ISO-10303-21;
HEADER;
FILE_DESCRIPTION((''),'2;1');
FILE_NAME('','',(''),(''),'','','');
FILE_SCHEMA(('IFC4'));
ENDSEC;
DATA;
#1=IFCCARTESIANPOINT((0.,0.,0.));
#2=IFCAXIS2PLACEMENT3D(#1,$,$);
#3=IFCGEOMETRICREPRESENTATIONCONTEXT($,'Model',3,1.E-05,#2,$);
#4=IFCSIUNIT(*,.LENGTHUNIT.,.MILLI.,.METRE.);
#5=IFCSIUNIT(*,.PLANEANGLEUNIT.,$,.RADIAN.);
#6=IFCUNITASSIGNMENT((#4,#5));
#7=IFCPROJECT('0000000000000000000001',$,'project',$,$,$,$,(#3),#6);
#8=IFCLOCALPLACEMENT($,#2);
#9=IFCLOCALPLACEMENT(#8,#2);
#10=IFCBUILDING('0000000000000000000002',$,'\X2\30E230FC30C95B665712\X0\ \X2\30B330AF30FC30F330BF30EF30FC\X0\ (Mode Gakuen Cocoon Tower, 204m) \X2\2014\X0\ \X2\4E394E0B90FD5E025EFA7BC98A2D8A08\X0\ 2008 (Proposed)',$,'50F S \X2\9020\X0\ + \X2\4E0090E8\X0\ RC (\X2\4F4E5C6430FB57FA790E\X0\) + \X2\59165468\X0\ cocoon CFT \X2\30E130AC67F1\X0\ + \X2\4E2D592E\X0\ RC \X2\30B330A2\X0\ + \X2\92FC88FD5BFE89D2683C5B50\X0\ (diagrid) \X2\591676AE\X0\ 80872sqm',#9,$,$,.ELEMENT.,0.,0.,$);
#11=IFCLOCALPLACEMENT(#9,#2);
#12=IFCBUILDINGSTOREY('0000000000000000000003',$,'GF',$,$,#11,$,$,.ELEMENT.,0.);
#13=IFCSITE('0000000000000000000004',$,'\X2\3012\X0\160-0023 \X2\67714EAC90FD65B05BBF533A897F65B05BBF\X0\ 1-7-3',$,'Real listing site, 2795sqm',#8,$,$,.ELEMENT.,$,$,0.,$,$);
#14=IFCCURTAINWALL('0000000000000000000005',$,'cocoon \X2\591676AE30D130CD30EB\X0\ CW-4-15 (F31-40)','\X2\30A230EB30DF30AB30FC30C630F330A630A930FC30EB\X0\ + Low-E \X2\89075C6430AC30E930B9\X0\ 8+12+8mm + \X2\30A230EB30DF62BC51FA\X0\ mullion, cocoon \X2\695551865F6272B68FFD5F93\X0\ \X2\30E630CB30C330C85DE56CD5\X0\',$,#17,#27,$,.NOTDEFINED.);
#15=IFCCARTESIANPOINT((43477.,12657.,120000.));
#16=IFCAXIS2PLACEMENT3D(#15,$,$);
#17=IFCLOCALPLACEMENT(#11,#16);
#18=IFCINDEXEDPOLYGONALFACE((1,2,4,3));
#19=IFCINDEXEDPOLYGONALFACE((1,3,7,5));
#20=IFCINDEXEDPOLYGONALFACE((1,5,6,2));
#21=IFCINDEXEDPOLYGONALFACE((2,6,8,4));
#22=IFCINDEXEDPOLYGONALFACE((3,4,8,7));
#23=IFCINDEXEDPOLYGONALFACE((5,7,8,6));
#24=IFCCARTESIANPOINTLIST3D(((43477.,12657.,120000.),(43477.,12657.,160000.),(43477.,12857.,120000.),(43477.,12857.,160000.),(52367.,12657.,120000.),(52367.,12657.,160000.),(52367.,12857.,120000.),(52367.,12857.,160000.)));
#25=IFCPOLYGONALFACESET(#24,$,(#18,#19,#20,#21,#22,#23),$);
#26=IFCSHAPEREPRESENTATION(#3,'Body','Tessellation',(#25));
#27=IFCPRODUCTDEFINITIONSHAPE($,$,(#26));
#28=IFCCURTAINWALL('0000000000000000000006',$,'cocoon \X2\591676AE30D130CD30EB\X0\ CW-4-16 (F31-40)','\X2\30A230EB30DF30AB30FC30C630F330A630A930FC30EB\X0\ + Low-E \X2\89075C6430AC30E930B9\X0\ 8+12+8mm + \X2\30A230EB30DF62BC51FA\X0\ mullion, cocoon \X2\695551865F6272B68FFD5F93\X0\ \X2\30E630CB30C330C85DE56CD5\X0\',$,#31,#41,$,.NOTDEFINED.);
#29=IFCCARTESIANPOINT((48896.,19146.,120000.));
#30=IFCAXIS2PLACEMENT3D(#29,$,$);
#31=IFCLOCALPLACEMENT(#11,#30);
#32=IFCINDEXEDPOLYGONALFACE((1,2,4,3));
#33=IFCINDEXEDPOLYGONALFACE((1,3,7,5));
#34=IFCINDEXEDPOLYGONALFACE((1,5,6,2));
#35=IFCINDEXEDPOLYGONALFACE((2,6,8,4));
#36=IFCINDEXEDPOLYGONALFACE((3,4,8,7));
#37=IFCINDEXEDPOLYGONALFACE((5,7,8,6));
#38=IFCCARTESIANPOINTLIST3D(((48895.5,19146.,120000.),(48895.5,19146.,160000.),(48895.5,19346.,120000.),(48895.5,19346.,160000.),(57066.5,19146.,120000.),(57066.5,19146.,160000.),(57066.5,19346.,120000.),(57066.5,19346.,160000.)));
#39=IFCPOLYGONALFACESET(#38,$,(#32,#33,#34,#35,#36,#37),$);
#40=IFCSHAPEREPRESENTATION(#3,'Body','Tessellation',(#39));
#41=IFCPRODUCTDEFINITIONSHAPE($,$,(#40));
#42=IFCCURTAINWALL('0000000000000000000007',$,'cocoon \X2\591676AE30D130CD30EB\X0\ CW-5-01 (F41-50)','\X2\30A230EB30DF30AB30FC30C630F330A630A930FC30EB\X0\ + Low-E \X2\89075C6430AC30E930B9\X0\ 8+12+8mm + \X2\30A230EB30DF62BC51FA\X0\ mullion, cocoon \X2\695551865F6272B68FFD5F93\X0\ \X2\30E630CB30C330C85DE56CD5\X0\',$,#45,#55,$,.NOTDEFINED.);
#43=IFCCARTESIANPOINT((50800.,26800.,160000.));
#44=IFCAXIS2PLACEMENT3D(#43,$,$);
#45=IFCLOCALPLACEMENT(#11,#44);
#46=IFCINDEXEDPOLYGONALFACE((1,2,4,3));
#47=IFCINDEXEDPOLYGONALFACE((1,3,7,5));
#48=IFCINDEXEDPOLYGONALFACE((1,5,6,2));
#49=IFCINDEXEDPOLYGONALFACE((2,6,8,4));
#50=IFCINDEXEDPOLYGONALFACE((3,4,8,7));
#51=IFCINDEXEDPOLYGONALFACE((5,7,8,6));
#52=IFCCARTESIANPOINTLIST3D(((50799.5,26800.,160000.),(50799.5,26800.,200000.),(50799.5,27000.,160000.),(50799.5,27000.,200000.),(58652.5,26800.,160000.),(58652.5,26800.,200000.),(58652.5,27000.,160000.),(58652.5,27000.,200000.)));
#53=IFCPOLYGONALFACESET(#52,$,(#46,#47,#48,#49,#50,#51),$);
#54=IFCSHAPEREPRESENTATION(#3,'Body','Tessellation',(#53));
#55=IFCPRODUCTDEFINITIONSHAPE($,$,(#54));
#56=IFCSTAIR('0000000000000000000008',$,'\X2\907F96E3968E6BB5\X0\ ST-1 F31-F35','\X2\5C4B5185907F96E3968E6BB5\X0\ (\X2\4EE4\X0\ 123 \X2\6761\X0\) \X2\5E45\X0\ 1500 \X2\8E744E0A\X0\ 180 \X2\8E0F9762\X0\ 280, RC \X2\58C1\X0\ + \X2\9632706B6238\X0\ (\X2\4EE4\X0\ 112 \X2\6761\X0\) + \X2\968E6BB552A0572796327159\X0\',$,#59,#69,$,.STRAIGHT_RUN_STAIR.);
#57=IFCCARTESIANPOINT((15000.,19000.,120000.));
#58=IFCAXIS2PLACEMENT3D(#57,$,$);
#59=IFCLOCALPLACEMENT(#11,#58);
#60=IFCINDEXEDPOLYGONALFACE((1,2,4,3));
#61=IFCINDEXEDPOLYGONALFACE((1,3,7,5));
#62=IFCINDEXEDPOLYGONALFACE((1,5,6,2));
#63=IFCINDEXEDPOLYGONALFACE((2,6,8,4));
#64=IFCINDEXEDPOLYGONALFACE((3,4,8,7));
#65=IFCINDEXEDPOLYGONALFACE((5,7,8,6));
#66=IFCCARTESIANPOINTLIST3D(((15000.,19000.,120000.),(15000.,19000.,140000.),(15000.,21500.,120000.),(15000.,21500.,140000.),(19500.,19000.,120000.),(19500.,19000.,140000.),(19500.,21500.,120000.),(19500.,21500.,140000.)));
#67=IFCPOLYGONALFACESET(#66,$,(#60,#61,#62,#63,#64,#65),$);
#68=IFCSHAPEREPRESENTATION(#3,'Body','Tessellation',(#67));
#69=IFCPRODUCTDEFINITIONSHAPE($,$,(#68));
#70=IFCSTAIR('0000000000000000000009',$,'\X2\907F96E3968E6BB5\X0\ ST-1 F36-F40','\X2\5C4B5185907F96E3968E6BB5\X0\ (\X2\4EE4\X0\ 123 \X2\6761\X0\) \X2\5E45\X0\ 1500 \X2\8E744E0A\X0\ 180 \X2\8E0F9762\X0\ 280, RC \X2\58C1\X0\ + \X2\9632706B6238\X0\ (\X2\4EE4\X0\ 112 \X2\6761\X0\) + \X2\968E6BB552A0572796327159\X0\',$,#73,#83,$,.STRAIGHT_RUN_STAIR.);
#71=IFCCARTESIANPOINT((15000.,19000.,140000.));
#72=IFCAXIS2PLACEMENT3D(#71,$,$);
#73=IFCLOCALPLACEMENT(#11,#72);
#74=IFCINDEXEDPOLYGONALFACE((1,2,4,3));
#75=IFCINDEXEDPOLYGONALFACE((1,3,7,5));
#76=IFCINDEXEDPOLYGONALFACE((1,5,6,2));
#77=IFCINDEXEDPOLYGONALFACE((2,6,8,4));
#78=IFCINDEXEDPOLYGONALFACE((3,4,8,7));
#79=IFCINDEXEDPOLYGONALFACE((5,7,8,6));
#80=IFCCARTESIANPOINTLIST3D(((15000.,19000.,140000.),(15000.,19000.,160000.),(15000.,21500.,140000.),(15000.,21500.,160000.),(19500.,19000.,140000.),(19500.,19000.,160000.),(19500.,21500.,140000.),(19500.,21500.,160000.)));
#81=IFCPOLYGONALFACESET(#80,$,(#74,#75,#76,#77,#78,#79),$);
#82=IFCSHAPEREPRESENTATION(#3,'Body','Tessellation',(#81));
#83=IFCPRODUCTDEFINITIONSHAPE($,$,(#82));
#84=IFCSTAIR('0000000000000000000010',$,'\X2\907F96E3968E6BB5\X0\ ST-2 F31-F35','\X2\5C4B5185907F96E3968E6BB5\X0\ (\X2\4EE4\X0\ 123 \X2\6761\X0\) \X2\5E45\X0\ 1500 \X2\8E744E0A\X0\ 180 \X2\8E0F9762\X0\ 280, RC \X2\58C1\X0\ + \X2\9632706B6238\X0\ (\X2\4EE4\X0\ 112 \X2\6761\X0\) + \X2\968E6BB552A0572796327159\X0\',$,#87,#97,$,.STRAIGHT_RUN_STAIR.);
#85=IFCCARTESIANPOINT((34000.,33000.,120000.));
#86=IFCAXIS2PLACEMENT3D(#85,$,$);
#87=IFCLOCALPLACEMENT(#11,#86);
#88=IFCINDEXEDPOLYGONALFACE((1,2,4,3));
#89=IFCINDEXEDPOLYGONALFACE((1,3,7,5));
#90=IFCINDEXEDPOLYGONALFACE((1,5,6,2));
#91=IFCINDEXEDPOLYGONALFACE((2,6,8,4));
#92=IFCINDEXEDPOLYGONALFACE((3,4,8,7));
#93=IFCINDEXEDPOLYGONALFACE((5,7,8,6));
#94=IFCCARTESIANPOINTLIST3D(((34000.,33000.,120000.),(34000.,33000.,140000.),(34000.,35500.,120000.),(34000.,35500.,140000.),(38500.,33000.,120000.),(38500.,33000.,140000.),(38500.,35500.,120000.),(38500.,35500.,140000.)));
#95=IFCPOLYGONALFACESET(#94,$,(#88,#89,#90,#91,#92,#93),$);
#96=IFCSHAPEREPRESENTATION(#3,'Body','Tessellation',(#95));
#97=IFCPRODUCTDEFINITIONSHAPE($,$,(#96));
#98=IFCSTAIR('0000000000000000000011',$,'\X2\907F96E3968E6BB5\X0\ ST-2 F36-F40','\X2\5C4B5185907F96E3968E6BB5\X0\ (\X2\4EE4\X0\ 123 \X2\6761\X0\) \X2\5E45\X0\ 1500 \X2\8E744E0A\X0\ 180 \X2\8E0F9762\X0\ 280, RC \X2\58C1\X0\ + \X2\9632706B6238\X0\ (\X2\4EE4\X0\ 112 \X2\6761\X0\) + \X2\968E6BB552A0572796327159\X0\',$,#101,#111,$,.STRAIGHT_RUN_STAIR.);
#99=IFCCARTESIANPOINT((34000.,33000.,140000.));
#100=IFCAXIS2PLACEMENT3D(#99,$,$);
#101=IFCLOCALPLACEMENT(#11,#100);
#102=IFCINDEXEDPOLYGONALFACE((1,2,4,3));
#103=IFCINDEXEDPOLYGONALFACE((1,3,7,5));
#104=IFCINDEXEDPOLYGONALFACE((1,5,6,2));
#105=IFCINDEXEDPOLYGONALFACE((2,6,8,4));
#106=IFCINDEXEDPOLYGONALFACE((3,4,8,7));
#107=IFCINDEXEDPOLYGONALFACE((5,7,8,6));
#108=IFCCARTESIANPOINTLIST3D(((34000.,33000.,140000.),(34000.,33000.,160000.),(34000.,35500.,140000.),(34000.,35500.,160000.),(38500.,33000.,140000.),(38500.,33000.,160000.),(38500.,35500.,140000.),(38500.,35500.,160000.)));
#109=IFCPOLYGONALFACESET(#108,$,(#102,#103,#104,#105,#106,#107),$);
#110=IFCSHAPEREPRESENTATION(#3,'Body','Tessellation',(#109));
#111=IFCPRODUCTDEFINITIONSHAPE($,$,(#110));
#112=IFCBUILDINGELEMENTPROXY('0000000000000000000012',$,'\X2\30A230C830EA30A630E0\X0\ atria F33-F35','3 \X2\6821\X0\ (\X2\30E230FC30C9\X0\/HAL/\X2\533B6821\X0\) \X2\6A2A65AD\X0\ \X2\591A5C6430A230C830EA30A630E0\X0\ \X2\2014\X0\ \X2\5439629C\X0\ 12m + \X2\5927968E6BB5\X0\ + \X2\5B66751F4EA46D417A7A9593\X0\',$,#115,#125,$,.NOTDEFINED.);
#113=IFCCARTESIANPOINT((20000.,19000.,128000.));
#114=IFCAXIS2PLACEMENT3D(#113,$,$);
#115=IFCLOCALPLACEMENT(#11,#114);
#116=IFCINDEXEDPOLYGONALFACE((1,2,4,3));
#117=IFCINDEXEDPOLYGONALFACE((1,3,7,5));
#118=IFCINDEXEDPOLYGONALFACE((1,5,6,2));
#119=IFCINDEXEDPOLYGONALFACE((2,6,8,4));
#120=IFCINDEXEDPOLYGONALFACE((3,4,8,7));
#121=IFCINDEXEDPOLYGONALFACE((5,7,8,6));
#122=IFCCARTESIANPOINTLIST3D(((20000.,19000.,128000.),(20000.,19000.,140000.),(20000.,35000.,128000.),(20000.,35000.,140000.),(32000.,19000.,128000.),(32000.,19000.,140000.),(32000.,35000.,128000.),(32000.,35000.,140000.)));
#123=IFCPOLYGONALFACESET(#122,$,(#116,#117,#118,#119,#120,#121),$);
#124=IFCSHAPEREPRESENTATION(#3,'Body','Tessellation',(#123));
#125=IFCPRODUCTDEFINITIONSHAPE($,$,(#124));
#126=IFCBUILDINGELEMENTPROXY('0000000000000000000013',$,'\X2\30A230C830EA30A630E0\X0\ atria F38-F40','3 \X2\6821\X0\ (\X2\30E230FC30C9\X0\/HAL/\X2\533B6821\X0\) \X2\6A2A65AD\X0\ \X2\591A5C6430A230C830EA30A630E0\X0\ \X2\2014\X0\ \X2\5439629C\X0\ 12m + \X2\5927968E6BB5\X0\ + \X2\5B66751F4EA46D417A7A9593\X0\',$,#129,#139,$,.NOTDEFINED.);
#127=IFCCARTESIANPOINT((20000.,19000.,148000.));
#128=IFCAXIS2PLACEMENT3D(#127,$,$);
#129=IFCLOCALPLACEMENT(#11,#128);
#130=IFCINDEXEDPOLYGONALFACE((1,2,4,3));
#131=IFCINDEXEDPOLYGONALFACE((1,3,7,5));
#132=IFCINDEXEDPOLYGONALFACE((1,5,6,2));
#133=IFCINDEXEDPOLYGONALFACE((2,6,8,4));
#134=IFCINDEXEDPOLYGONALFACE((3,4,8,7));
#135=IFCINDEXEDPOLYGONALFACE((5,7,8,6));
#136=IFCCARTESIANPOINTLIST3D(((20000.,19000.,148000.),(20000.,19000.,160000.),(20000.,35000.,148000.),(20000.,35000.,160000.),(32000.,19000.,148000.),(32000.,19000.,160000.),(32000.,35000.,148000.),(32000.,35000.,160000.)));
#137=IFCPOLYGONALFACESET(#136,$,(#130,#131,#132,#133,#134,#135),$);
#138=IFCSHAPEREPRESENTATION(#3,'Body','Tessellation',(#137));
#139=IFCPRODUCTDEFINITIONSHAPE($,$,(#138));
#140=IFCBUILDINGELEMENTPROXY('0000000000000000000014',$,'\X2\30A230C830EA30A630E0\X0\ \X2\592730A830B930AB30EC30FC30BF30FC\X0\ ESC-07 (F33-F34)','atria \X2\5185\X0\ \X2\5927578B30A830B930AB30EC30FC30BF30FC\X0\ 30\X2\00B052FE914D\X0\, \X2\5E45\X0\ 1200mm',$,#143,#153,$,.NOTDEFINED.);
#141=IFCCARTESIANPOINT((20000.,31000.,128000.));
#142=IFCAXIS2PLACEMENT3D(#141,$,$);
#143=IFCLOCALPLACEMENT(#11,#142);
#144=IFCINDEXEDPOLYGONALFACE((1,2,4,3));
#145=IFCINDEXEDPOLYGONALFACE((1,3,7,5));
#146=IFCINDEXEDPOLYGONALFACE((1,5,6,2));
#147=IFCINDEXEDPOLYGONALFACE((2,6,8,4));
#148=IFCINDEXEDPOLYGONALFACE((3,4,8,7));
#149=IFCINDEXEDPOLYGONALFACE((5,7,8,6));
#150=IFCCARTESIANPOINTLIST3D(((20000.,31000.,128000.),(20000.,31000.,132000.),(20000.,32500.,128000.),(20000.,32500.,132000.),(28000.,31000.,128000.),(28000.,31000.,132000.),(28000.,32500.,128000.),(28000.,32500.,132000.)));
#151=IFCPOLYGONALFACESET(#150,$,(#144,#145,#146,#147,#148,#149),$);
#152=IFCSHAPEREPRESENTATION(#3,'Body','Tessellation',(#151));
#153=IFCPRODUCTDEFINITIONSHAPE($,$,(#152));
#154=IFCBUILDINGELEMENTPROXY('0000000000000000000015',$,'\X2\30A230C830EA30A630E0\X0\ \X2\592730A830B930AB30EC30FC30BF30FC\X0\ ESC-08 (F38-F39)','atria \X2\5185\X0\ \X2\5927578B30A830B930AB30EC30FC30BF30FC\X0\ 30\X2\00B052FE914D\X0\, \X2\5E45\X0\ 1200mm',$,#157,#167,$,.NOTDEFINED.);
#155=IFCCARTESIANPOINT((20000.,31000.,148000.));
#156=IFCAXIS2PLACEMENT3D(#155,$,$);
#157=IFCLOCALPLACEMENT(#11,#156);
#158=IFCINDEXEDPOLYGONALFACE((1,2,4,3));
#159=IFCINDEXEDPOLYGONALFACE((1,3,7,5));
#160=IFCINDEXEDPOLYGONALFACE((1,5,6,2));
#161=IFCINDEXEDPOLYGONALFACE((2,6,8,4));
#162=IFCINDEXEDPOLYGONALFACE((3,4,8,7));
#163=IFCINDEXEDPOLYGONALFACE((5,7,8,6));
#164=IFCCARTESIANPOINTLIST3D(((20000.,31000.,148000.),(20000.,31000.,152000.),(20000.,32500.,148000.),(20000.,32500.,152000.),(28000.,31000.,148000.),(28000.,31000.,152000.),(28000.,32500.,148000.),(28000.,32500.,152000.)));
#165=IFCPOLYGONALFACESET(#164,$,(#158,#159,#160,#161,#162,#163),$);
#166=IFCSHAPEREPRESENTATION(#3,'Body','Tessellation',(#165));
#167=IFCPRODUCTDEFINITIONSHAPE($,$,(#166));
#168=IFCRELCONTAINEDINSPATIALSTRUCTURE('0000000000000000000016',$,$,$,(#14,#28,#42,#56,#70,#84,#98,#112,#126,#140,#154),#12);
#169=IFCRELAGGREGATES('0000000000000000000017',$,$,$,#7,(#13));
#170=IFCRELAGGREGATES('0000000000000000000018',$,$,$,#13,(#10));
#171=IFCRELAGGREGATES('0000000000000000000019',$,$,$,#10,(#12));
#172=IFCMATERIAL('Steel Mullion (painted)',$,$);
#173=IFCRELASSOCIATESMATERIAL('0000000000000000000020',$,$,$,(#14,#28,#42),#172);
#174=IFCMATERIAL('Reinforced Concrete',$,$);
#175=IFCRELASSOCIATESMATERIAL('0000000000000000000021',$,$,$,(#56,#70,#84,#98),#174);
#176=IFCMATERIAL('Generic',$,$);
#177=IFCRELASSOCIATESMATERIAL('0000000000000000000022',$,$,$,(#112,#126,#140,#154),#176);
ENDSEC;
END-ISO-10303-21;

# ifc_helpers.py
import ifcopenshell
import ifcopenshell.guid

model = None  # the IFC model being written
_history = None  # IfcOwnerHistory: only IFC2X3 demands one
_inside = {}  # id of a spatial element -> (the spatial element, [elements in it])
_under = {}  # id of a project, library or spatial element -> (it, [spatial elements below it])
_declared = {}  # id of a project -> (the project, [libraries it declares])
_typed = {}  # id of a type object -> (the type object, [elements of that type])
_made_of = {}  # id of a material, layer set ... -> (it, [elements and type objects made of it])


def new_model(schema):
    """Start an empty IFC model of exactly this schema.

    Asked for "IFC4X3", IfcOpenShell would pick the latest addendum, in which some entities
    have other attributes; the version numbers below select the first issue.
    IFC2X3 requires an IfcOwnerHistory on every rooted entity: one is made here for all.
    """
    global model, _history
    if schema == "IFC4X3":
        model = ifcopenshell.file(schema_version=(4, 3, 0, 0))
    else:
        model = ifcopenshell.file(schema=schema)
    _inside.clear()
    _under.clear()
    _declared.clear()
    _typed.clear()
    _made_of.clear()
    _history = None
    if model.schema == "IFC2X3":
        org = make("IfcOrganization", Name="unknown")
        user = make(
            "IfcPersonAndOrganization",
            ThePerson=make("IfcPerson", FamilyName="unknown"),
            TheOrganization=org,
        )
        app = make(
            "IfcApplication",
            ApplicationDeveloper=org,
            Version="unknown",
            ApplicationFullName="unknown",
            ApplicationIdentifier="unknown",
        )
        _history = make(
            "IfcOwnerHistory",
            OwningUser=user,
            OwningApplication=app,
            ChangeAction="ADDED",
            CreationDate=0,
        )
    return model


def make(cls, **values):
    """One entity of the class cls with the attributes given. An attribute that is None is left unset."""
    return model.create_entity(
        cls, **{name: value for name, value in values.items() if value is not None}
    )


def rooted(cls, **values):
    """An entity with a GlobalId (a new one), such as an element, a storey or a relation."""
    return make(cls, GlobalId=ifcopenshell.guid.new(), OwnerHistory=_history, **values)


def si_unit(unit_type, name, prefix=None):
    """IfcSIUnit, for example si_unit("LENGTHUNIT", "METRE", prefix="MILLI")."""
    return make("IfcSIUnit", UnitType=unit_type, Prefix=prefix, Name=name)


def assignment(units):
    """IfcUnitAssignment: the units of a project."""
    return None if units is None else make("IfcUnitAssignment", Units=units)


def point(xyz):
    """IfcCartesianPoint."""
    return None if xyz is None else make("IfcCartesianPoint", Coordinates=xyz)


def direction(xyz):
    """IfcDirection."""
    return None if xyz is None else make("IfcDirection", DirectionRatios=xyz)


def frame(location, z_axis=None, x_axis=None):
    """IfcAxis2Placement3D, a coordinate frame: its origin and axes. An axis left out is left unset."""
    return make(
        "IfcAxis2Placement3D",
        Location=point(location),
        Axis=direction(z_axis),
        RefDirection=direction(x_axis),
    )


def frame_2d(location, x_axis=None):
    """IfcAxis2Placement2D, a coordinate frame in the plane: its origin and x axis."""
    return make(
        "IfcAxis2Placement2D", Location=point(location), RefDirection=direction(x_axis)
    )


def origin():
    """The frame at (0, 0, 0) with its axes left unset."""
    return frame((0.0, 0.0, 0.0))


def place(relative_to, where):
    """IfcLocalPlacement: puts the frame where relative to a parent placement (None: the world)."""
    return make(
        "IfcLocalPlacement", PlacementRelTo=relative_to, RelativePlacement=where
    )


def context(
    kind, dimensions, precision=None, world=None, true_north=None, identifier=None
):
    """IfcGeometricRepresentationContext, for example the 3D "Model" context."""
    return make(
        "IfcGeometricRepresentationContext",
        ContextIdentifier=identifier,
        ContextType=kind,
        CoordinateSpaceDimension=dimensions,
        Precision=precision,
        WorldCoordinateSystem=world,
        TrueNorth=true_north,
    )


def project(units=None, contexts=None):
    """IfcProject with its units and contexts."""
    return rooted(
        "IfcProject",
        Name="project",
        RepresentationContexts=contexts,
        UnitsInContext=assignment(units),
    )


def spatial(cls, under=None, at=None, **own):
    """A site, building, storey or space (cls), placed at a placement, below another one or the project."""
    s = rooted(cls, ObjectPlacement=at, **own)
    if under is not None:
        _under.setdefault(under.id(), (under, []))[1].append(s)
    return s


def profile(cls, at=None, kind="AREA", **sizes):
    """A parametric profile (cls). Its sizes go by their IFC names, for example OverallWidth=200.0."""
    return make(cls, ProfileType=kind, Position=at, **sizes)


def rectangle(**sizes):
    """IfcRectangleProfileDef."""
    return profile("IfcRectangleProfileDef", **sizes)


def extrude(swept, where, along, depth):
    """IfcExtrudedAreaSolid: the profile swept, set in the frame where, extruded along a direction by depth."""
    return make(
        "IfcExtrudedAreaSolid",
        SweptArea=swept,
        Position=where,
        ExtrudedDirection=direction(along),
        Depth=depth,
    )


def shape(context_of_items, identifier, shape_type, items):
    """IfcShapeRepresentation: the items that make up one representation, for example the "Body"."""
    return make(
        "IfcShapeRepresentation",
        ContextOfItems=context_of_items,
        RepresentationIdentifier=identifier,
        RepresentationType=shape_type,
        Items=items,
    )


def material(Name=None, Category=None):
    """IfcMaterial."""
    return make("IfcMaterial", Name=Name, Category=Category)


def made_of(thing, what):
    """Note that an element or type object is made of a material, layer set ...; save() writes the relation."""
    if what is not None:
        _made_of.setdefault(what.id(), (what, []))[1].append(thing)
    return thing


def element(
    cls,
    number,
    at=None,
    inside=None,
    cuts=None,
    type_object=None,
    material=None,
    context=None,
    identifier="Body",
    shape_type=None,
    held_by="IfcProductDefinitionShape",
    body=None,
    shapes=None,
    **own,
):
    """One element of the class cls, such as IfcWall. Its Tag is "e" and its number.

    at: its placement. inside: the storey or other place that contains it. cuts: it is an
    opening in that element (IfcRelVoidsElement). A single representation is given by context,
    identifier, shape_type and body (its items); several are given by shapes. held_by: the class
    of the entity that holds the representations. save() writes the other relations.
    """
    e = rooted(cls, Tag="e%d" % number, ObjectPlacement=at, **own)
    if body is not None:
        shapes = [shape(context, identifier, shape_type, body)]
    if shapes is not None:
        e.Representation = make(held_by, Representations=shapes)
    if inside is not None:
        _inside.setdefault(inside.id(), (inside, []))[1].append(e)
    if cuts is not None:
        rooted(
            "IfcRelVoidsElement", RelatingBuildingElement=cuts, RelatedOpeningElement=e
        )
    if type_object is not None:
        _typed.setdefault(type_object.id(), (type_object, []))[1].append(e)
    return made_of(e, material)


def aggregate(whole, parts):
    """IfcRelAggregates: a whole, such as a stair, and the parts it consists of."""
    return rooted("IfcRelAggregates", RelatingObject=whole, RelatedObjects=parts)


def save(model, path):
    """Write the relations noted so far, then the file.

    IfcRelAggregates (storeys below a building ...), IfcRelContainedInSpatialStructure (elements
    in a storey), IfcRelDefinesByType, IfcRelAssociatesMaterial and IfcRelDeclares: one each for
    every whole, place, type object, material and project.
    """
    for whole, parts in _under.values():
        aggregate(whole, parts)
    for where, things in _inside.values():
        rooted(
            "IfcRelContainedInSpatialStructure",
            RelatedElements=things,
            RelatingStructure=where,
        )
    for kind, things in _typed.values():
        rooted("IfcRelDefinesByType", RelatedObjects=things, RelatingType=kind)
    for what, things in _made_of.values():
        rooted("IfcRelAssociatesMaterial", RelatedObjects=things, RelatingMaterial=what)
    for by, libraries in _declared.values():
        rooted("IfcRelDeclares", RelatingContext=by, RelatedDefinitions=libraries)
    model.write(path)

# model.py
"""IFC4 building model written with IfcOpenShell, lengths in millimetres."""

from ifc_helpers import new_model, si_unit, frame, frame_2d, origin, place, context, project, spatial, rectangle, extrude, material, element, save


model = new_model("IFC4")

# Units and contexts
model_context = context("Model", 3, precision=1e-05, world=origin())
ifc_project = project(units=[si_unit("LENGTHUNIT", "METRE", prefix="MILLI"), si_unit("PLANEANGLEUNIT", "RADIAN")], contexts=[model_context])

# Site, building, storey
site_placement = place(None, origin())
site = spatial("IfcSite", under=ifc_project, at=site_placement, Name="〒160-0023 東京都新宿区西新宿 1-7-3", ObjectType="Real listing site, 2795sqm", CompositionType="ELEMENT", RefElevation=0.0)
building_placement = place(site_placement, origin())
building = spatial("IfcBuilding", under=site, at=building_placement, Name="モード学園 コクーンタワー (Mode Gakuen Cocoon Tower, 204m) — 丹下都市建築設計 2008 (Proposed)", ObjectType="50F S 造 + 一部 RC (低層・基礎) + 外周 cocoon CFT メガ柱 + 中央 RC コア + 鋼製対角格子 (diagrid) 外皮 80872sqm", CompositionType="ELEMENT", ElevationOfRefHeight=0.0, ElevationOfTerrain=0.0)
storey_placement = place(building_placement, origin())
storey = spatial("IfcBuildingStorey", under=building, at=storey_placement, Name="GF", CompositionType="ELEMENT", Elevation=0.0)

# Shared definitions
ifc_material_1 = material(Name="Generic")

# Curtain walls
ifc_material_2 = material(Name="Steel Mullion (painted)")
curtain_wall_1_placement = place(storey_placement, frame((43477.0, 12657.0, 120000.0)))
element("IfcCurtainWall", 1, at=curtain_wall_1_placement, inside=storey, material=ifc_material_2, Name="cocoon 外皮パネル CW-4-15 (F31-40)", Description="アルミカーテンウォール + Low-E 複層ガラス 8+12+8mm + アルミ押出 mullion, cocoon 楕円形状追従 ユニット工法", PredefinedType="NOTDEFINED", context=model_context, shape_type="SweptSolid", body=[
    extrude(rectangle(XDim=8890.0, YDim=200.0, at=frame_2d((4445.0, 100.0))), frame((43477.0, 12657.0, 120000.0)), (0.0, 0.0, 1.0), 40000.0),
])
curtain_wall_2_placement = place(storey_placement, frame((48896.0, 19146.0, 120000.0)))
element("IfcCurtainWall", 2, at=curtain_wall_2_placement, inside=storey, material=ifc_material_2, Name="cocoon 外皮パネル CW-4-16 (F31-40)", Description="アルミカーテンウォール + Low-E 複層ガラス 8+12+8mm + アルミ押出 mullion, cocoon 楕円形状追従 ユニット工法", PredefinedType="NOTDEFINED", context=model_context, shape_type="SweptSolid", body=[
    extrude(rectangle(XDim=8171.0, YDim=200.0, at=frame_2d((4085.0, 100.0))), frame((48896.0, 19146.0, 120000.0)), (0.0, 0.0, 1.0), 40000.0),
])
curtain_wall_3_placement = place(storey_placement, frame((50800.0, 26800.0, 160000.0)))
element("IfcCurtainWall", 3, at=curtain_wall_3_placement, inside=storey, material=ifc_material_2, Name="cocoon 外皮パネル CW-5-01 (F41-50)", Description="アルミカーテンウォール + Low-E 複層ガラス 8+12+8mm + アルミ押出 mullion, cocoon 楕円形状追従 ユニット工法", PredefinedType="NOTDEFINED", context=model_context, shape_type="SweptSolid", body=[
    extrude(rectangle(XDim=7853.0, YDim=200.0, at=frame_2d((3926.0, 100.0))), frame((50800.0, 26800.0, 160000.0)), (0.0, 0.0, 1.0), 40000.0),
])

# Stairs
ifc_material_3 = material(Name="Reinforced Concrete")
stair_1_placement = place(storey_placement, frame((15000.0, 19000.0, 120000.0)))
element("IfcStair", 4, at=stair_1_placement, inside=storey, material=ifc_material_3, Name="避難階段 ST-1 F31-F35", Description="屋内避難階段 (令 123 条) 幅 1500 蹴上 180 踏面 280, RC 壁 + 防火戸 (令 112 条) + 階段加圧防煙", PredefinedType="STRAIGHT_RUN_STAIR", context=model_context, shape_type="SweptSolid", body=[
    extrude(rectangle(XDim=4500.0, YDim=2500.0, at=frame_2d((2250.0, 1250.0))), frame((15000.0, 19000.0, 120000.0)), (0.0, 0.0, 1.0), 20000.0),
])
stair_2_placement = place(storey_placement, frame((15000.0, 19000.0, 140000.0)))
element("IfcStair", 5, at=stair_2_placement, inside=storey, material=ifc_material_3, Name="避難階段 ST-1 F36-F40", Description="屋内避難階段 (令 123 条) 幅 1500 蹴上 180 踏面 280, RC 壁 + 防火戸 (令 112 条) + 階段加圧防煙", PredefinedType="STRAIGHT_RUN_STAIR", context=model_context, shape_type="SweptSolid", body=[
    extrude(rectangle(XDim=4500.0, YDim=2500.0, at=frame_2d((2250.0, 1250.0))), frame((15000.0, 19000.0, 140000.0)), (0.0, 0.0, 1.0), 20000.0),
])
stair_3_placement = place(storey_placement, frame((34000.0, 33000.0, 120000.0)))
element("IfcStair", 6, at=stair_3_placement, inside=storey, material=ifc_material_3, Name="避難階段 ST-2 F31-F35", Description="屋内避難階段 (令 123 条) 幅 1500 蹴上 180 踏面 280, RC 壁 + 防火戸 (令 112 条) + 階段加圧防煙", PredefinedType="STRAIGHT_RUN_STAIR", context=model_context, shape_type="SweptSolid", body=[
    extrude(rectangle(XDim=4500.0, YDim=2500.0, at=frame_2d((2250.0, 1250.0))), frame((34000.0, 33000.0, 120000.0)), (0.0, 0.0, 1.0), 20000.0),
])
stair_4_placement = place(storey_placement, frame((34000.0, 33000.0, 140000.0)))
element("IfcStair", 7, at=stair_4_placement, inside=storey, material=ifc_material_3, Name="避難階段 ST-2 F36-F40", Description="屋内避難階段 (令 123 条) 幅 1500 蹴上 180 踏面 280, RC 壁 + 防火戸 (令 112 条) + 階段加圧防煙", PredefinedType="STRAIGHT_RUN_STAIR", context=model_context, shape_type="SweptSolid", body=[
    extrude(rectangle(XDim=4500.0, YDim=2500.0, at=frame_2d((2250.0, 1250.0))), frame((34000.0, 33000.0, 140000.0)), (0.0, 0.0, 1.0), 20000.0),
])

# Building element proxies
proxy_1_placement = place(storey_placement, frame((20000.0, 19000.0, 128000.0)))
element("IfcBuildingElementProxy", 8, at=proxy_1_placement, inside=storey, material=ifc_material_1, Name="アトリウム atria F33-F35", Description="3 校 (モード/HAL/医校) 横断 多層アトリウム — 吹抜 12m + 大階段 + 学生交流空間", PredefinedType="NOTDEFINED", context=model_context, shape_type="SweptSolid", body=[
    extrude(rectangle(XDim=12000.0, YDim=16000.0, at=frame_2d((6000.0, 8000.0))), frame((20000.0, 19000.0, 128000.0)), (0.0, 0.0, 1.0), 12000.0),
])
proxy_2_placement = place(storey_placement, frame((20000.0, 19000.0, 148000.0)))
element("IfcBuildingElementProxy", 9, at=proxy_2_placement, inside=storey, material=ifc_material_1, Name="アトリウム atria F38-F40", Description="3 校 (モード/HAL/医校) 横断 多層アトリウム — 吹抜 12m + 大階段 + 学生交流空間", PredefinedType="NOTDEFINED", context=model_context, shape_type="SweptSolid", body=[
    extrude(rectangle(XDim=12000.0, YDim=16000.0, at=frame_2d((6000.0, 8000.0))), frame((20000.0, 19000.0, 148000.0)), (0.0, 0.0, 1.0), 12000.0),
])
proxy_3_placement = place(storey_placement, frame((20000.0, 31000.0, 128000.0)))
element("IfcBuildingElementProxy", 10, at=proxy_3_placement, inside=storey, material=ifc_material_1, Name="アトリウム 大エスカレーター ESC-07 (F33-F34)", Description="atria 内 大型エスカレーター 30°勾配, 幅 1200mm", PredefinedType="NOTDEFINED", context=model_context, shape_type="SweptSolid", body=[
    extrude(rectangle(XDim=8000.0, YDim=1500.0, at=frame_2d((4000.0, 750.0))), frame((20000.0, 31000.0, 128000.0)), (0.0, 0.0, 1.0), 4000.0),
])
proxy_4_placement = place(storey_placement, frame((20000.0, 31000.0, 148000.0)))
element("IfcBuildingElementProxy", 11, at=proxy_4_placement, inside=storey, material=ifc_material_1, Name="アトリウム 大エスカレーター ESC-08 (F38-F39)", Description="atria 内 大型エスカレーター 30°勾配, 幅 1200mm", PredefinedType="NOTDEFINED", context=model_context, shape_type="SweptSolid", body=[
    extrude(rectangle(XDim=8000.0, YDim=1500.0, at=frame_2d((4000.0, 750.0))), frame((20000.0, 31000.0, 148000.0)), (0.0, 0.0, 1.0), 4000.0),
])

save(model, "model.ifc")
